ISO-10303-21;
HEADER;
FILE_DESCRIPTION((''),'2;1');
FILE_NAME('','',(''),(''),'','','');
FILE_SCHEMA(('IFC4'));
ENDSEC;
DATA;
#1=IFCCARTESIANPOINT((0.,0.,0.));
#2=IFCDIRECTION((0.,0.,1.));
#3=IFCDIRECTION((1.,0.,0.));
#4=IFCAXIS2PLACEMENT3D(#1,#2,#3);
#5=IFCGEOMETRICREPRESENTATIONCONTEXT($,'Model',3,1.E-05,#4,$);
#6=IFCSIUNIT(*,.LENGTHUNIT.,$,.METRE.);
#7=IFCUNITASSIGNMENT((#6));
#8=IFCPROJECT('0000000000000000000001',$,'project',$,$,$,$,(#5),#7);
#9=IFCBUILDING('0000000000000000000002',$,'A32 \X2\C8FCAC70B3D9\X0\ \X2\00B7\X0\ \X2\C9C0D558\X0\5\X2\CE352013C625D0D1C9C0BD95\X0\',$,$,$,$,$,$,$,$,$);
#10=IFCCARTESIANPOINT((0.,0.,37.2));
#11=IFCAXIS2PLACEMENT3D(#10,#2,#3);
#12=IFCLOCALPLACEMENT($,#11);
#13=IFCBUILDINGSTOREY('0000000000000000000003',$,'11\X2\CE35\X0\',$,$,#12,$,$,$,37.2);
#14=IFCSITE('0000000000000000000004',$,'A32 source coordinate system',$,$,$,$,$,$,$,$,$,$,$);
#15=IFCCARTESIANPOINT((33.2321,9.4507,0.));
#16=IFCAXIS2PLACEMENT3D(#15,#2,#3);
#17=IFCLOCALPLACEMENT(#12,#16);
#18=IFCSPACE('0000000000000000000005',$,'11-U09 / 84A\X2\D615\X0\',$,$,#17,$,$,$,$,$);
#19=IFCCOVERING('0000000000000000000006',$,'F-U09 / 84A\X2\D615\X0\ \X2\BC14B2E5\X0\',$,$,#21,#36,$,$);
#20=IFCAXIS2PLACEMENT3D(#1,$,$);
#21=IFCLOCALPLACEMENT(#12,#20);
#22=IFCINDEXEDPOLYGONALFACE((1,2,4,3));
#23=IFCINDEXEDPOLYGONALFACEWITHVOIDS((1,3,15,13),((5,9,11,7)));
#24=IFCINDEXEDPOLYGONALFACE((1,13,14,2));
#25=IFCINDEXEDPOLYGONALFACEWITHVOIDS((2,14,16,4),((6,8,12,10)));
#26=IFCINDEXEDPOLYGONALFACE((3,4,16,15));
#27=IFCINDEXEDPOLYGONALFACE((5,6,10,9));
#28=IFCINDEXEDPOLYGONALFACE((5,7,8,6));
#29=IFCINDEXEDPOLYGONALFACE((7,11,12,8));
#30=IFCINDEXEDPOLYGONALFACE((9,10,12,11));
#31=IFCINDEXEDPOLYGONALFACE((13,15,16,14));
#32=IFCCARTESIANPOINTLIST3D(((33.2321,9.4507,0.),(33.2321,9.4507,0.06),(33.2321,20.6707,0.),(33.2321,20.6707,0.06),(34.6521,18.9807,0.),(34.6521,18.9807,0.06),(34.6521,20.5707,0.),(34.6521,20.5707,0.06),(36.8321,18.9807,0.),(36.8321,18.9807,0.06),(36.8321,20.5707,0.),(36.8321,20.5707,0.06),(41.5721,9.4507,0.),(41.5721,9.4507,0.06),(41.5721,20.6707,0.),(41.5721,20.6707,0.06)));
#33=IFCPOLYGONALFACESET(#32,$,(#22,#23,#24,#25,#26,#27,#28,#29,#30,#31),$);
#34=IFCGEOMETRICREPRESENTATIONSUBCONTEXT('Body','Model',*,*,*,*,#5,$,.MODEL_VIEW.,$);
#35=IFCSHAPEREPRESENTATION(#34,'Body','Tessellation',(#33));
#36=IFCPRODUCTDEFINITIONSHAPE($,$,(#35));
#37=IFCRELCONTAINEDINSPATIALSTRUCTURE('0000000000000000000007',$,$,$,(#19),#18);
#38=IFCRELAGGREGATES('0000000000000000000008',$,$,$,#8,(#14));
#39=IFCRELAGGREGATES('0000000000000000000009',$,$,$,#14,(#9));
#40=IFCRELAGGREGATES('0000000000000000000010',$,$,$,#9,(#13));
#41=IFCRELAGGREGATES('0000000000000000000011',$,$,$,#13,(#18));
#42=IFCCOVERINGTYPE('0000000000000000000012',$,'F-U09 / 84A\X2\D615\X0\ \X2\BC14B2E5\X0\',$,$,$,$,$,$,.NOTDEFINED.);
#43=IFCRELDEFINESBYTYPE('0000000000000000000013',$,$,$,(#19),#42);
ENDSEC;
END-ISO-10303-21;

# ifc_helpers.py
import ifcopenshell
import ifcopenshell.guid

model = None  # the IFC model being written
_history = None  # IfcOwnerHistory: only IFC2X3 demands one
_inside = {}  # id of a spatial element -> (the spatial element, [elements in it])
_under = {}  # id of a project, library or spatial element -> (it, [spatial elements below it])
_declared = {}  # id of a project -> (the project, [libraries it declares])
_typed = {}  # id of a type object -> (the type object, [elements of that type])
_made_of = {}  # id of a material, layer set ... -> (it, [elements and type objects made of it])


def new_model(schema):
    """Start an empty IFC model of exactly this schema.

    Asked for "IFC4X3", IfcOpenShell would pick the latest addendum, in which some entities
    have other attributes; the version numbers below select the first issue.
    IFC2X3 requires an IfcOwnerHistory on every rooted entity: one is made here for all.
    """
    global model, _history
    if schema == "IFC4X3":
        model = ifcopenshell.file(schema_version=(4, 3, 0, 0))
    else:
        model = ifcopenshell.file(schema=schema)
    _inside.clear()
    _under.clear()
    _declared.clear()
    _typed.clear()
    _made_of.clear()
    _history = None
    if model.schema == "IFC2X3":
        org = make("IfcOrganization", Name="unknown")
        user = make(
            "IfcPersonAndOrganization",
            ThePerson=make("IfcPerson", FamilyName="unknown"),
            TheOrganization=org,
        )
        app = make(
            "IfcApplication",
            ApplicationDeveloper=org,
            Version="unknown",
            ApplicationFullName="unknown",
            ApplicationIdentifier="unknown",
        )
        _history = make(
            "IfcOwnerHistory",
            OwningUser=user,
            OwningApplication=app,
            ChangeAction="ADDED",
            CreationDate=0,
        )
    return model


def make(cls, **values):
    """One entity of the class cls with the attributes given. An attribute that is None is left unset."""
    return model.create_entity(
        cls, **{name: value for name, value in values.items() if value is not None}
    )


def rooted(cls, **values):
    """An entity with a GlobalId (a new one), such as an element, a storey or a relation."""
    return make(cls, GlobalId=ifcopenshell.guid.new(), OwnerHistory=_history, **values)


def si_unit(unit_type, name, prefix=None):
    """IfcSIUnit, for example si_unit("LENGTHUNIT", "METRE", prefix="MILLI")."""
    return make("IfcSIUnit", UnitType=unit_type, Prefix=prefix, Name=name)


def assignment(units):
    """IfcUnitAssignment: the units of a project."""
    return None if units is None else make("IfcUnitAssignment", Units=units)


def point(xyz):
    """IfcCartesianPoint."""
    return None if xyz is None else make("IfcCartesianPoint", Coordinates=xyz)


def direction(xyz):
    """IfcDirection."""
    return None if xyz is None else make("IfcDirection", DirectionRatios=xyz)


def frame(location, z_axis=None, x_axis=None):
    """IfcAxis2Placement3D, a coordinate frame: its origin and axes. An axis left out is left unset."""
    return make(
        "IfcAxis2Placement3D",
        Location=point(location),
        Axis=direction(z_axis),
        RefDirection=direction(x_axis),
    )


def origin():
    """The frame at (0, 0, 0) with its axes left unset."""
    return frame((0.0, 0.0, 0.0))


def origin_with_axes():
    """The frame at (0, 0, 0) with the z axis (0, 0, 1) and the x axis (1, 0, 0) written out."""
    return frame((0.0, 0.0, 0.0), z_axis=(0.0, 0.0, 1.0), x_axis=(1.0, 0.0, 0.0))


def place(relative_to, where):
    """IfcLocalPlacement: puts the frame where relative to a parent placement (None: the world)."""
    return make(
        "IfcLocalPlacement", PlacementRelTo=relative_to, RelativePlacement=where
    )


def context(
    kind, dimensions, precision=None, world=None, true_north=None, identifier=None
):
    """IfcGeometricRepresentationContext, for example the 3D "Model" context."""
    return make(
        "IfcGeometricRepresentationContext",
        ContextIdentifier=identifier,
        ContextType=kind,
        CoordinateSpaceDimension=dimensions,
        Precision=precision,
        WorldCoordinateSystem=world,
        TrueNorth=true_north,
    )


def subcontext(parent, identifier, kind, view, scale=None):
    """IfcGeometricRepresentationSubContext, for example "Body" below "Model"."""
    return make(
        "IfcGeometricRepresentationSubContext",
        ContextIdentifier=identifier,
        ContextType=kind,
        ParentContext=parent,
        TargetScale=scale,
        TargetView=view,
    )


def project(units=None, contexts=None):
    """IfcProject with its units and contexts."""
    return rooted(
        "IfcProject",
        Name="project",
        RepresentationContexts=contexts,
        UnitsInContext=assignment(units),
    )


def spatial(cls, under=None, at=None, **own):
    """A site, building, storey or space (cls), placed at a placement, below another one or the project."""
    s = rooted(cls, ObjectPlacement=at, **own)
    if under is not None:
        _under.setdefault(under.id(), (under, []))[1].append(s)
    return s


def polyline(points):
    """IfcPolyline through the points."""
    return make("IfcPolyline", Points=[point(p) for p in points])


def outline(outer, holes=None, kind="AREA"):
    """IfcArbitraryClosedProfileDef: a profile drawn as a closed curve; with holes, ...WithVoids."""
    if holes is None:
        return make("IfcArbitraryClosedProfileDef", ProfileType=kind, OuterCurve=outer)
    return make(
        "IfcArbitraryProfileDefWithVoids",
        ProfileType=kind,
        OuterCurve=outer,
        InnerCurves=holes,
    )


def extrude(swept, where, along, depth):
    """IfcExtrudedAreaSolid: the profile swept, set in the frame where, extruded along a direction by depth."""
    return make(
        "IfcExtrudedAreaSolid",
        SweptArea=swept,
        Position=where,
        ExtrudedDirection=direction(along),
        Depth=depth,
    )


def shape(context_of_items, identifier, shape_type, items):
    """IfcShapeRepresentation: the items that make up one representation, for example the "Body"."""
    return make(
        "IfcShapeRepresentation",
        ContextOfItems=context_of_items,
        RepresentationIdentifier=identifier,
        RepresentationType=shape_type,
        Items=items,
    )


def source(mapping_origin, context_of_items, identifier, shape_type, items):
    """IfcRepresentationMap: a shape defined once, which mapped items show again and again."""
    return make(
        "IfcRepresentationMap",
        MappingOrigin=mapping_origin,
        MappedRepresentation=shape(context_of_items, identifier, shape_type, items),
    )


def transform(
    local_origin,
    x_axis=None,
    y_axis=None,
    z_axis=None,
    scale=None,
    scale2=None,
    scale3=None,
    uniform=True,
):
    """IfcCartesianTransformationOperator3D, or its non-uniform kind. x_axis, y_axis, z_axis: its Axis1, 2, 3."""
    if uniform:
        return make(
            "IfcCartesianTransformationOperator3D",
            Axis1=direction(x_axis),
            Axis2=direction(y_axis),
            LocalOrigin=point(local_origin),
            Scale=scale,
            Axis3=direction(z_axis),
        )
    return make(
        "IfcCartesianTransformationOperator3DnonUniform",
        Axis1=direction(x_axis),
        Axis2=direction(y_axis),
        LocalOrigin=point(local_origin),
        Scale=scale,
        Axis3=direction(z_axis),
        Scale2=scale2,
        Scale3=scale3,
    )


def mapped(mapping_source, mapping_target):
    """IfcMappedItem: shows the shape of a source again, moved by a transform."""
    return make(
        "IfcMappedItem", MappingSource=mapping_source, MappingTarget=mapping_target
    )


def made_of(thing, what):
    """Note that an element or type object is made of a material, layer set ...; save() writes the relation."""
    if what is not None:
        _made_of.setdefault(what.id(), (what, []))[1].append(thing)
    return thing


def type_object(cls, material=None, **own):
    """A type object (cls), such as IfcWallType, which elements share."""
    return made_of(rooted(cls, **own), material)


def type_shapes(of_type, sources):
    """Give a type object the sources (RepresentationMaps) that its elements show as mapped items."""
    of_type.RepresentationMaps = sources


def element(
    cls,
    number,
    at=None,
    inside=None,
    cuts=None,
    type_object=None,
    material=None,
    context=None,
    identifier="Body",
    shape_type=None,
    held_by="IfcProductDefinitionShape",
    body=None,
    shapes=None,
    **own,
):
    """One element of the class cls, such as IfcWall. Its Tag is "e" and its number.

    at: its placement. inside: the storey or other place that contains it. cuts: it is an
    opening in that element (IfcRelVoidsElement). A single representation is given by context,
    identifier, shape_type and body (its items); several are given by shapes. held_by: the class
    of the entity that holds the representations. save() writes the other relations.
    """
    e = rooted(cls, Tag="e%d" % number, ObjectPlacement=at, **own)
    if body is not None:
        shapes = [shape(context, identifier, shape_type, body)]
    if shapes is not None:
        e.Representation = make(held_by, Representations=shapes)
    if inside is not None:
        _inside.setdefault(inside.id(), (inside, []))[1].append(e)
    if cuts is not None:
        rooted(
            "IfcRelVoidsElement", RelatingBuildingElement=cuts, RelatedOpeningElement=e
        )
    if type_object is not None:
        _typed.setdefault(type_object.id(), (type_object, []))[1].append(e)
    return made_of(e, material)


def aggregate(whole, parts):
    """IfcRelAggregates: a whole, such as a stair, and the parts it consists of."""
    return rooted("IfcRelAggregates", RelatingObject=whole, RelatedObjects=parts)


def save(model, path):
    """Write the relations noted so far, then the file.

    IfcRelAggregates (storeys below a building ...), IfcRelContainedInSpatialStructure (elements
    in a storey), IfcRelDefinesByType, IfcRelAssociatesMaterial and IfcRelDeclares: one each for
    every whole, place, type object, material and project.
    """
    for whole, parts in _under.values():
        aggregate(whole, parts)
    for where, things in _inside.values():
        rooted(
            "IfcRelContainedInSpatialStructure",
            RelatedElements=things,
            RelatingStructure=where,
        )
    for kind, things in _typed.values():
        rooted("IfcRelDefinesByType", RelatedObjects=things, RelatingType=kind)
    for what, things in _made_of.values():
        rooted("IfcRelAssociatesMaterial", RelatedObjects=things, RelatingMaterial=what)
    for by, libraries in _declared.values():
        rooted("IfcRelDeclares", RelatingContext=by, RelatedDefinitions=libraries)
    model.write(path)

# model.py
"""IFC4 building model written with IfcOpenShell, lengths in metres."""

from ifc_helpers import new_model, si_unit, frame, origin, origin_with_axes, place, context, subcontext, project, spatial, polyline, outline, extrude, source, transform, mapped, type_object, type_shapes, element, save


model = new_model("IFC4")

# Units and contexts
model_context = context("Model", 3, precision=1e-05, world=origin_with_axes())
body_context = subcontext(model_context, "Body", "Model", "MODEL_VIEW")
ifc_project = project(units=[si_unit("LENGTHUNIT", "METRE")], contexts=[model_context])

# Site, building, storey, space
storey_placement = place(None, frame((0.0, 0.0, 37.2), z_axis=(0.0, 0.0, 1.0), x_axis=(1.0, 0.0, 0.0)))
space_placement = place(storey_placement, frame((33.2321, 9.4507, 0.0), z_axis=(0.0, 0.0, 1.0), x_axis=(1.0, 0.0, 0.0)))
site = spatial("IfcSite", under=ifc_project, Name="A32 source coordinate system")
building = spatial("IfcBuilding", under=site, Name="A32 주거동 · 지하5층–옥탑지붕")
storey = spatial("IfcBuildingStorey", under=building, at=storey_placement, Name="11층", Elevation=37.2)
space = spatial("IfcSpace", under=storey, at=space_placement, Name="11-U09 / 84A형")

# Covering
covering_type_1 = type_object("IfcCoveringType", Name="F-U09 / 84A형 바닥", PredefinedType="NOTDEFINED")
shared_shape_1 = source(origin(), body_context, "Body", "SweptSolid", [
    extrude(outline(polyline([(0.0, 0.0), (0.0, 11.22), (8.34, 11.22), (8.34, 0.0), (0.0, 0.0)]), holes=[polyline([(1.42, 11.12), (1.42, 9.53), (3.6, 9.53), (3.6, 11.12), (1.42, 11.12)])]), origin(), (0.0, 0.0, 1.0), 0.06),
])
type_shapes(covering_type_1, [shared_shape_1])
covering_1_placement = place(space_placement, origin_with_axes())
element("IfcCovering", 1, at=covering_1_placement, inside=space, type_object=covering_type_1, Name="F-U09 / 84A형 바닥", context=body_context, shape_type="MappedRepresentation", body=[
    mapped(shared_shape_1, transform((0.0, 0.0, 0.0), scale=1.0)),
])

save(model, "model.ifc")
